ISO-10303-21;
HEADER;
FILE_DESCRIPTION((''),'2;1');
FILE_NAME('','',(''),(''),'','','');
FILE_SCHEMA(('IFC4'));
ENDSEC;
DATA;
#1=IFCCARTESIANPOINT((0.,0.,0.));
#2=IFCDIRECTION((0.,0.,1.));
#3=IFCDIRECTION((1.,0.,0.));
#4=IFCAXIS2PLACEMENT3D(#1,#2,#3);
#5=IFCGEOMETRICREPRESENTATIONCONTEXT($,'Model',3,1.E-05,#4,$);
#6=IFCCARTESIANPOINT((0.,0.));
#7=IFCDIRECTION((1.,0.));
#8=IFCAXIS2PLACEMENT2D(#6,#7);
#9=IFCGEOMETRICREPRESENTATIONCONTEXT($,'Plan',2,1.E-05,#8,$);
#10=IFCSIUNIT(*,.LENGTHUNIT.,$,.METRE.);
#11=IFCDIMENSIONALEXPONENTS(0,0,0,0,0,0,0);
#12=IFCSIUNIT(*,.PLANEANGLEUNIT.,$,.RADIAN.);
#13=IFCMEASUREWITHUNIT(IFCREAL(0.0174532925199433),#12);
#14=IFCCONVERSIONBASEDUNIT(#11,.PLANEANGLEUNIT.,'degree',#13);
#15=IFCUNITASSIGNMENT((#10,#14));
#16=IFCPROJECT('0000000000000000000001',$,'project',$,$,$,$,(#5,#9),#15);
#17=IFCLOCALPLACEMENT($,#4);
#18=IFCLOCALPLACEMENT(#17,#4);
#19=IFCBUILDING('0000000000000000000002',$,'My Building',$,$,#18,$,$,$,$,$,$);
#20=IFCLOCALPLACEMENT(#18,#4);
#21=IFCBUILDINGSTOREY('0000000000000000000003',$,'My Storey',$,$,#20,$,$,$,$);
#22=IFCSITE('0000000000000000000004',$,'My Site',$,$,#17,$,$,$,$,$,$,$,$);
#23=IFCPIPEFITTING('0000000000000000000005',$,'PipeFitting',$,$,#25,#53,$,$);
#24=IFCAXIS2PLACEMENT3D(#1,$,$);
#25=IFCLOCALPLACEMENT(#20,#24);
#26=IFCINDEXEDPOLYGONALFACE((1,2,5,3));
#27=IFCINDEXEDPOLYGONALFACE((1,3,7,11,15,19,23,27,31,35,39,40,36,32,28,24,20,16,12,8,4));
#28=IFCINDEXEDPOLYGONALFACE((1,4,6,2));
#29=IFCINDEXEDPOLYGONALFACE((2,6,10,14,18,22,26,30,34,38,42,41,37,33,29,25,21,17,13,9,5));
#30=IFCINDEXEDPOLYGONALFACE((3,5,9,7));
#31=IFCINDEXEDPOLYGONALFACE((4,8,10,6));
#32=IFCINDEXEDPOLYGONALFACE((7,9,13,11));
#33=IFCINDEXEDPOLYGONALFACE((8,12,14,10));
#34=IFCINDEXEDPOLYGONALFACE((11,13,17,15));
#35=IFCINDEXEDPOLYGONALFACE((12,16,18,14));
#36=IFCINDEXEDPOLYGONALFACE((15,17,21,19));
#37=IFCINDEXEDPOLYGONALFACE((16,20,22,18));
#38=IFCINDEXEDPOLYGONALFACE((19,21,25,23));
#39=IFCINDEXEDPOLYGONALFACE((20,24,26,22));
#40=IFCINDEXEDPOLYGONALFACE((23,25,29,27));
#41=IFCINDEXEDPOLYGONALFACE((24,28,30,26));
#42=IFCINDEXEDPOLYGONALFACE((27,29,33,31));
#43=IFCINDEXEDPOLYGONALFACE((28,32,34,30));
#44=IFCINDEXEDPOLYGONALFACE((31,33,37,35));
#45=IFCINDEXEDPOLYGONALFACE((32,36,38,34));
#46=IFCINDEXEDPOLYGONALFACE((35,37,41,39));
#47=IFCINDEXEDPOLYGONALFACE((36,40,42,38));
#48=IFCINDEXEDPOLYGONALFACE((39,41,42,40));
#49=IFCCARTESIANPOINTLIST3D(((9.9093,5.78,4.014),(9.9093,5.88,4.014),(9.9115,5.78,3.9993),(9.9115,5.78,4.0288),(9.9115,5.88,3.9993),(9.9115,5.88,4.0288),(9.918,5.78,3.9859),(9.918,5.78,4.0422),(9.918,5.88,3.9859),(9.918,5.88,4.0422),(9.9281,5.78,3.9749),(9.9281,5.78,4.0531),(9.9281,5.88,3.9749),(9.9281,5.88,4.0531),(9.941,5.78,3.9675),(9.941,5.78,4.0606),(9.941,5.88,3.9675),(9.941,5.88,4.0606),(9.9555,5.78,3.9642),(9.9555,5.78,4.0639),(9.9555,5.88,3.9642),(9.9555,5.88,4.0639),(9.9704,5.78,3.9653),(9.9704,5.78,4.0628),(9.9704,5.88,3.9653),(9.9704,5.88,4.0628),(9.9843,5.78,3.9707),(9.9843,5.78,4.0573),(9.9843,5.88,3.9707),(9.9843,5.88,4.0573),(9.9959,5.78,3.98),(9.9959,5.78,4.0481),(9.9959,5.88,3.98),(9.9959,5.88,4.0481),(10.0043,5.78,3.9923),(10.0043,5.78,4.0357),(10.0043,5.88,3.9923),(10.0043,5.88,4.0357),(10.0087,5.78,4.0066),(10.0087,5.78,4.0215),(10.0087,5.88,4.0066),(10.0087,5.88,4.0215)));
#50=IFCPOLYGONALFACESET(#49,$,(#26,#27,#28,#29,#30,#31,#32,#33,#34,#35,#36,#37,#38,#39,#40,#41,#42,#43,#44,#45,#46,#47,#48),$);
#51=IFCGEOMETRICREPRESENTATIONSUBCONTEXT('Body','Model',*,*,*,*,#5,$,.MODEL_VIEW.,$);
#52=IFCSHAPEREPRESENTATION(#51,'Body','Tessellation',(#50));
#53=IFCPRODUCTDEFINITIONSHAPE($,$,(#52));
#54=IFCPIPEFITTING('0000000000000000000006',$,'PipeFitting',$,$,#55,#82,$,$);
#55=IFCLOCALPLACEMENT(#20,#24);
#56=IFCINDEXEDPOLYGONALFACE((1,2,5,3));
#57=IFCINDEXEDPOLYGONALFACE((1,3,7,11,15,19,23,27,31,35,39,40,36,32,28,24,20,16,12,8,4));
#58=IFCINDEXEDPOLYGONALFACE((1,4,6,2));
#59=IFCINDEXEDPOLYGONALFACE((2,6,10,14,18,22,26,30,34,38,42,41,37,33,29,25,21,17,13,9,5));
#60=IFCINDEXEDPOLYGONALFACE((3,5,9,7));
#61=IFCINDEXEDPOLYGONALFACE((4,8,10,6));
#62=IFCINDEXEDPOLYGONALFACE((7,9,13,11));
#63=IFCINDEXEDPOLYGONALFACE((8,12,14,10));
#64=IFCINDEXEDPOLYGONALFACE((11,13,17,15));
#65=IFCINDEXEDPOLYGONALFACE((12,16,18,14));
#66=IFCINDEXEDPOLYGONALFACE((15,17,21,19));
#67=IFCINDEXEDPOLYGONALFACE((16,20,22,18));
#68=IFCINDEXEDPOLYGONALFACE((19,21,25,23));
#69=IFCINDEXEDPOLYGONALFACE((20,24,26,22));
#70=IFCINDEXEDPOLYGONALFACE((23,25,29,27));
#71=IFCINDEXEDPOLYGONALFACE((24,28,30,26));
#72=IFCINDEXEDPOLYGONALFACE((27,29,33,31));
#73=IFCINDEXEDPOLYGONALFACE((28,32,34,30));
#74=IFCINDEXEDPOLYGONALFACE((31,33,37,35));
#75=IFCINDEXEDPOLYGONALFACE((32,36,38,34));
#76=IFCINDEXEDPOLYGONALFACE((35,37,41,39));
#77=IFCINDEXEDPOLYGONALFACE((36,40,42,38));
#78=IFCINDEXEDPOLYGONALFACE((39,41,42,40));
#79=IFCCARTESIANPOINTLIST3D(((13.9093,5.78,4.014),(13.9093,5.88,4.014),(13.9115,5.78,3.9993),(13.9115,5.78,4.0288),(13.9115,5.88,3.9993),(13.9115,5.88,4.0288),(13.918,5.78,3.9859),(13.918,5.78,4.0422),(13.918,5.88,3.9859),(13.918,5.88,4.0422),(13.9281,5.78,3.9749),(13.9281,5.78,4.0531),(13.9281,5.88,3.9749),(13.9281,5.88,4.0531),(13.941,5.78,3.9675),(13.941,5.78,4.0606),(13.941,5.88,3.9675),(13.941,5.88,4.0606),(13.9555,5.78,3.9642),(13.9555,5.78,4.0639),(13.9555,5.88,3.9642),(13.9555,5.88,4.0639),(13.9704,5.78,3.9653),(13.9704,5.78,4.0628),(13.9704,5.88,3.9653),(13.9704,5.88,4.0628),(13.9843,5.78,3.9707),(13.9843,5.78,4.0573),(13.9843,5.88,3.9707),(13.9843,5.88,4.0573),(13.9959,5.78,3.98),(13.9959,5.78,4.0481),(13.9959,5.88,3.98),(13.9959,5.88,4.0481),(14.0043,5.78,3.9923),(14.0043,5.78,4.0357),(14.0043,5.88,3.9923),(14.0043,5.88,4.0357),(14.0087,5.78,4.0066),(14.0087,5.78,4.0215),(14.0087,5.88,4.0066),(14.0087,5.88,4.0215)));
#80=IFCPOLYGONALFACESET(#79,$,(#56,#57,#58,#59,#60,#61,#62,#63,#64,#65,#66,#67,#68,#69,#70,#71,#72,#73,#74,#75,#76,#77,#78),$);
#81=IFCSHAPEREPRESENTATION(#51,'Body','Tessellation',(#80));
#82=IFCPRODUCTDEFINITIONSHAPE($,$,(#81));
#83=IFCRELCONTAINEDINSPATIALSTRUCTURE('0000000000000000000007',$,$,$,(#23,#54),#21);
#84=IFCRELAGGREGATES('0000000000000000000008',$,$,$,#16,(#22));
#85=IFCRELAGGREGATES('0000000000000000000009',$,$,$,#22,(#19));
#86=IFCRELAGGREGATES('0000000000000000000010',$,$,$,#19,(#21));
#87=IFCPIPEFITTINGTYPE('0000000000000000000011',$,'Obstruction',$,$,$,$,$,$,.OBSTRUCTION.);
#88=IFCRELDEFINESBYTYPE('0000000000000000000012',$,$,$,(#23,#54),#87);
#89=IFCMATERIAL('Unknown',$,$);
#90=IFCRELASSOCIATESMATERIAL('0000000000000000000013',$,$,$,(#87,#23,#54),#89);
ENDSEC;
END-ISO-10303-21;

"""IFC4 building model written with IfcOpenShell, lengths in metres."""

from ifc_helpers import new_model, entity, si_unit, converted_unit, frame, origin_with_axes, origin_2d_with_axis, place, context, subcontext, project, spatial, circle, extrude, material, material_profile, profile_set, profile_usage, type_object, element, save


model = new_model("IFC4")

# Units and contexts
model_context = context("Model", 3, precision=1e-05, world=origin_with_axes())
plan_context = context("Plan", 2, precision=1e-05, world=origin_2d_with_axis())
body_context_1 = subcontext(model_context, "Body", "Model", "MODEL_VIEW")
ifc_project = project(units=[si_unit("LENGTHUNIT", "METRE"), converted_unit("PLANEANGLEUNIT", "degree", entity("IfcReal", 0.0174532925199433), si_unit("PLANEANGLEUNIT", "RADIAN"), dimensions=[0, 0, 0, 0, 0, 0, 0])], contexts=[model_context, plan_context])

# Site, building, storey
site_placement = place(None, origin_with_axes())
site = spatial("IfcSite", under=ifc_project, at=site_placement, Name="My Site")
building_placement = place(site_placement, origin_with_axes())
building = spatial("IfcBuilding", under=site, at=building_placement, Name="My Building")
storey_placement = place(building_placement, origin_with_axes())
storey = spatial("IfcBuildingStorey", under=building, at=storey_placement, Name="My Storey")

# Shared definitions
ifc_material = material(Name="Unknown")

# Pipe fittings
ifc_material_profile_1 = material_profile(ifc_material, circle(Radius=0.05))
ifc_profile_set_1 = profile_set([ifc_material_profile_1])
ifc_profile_usage_1 = profile_usage(ifc_profile_set_1, cardinal=5)
pipe_fitting_type_1 = type_object("IfcPipeFittingType", Name="Obstruction", PredefinedType="OBSTRUCTION", material=ifc_profile_set_1)
pipe_fitting_1_placement = place(storey_placement, frame((9.9593, 5.78, 4.014), z_axis=(0.0, 1.0, 0.0), x_axis=(-1.0, 0.0, 0.0)))
element("IfcPipeFitting", 1, at=pipe_fitting_1_placement, inside=storey, type_object=pipe_fitting_type_1, material=ifc_profile_usage_1, Name="PipeFitting", context=body_context_1, shape_type="SweptSolid", body=[
    extrude(circle(Radius=0.05), origin_with_axes(), (0.0, 0.0, 1.0), 0.1),
])
ifc_profile_usage_2 = profile_usage(ifc_profile_set_1, cardinal=5)
pipe_fitting_2_placement = place(storey_placement, frame((13.9593, 5.78, 4.014), z_axis=(0.0, 1.0, 0.0), x_axis=(-1.0, 0.0, 0.0)))
element("IfcPipeFitting", 2, at=pipe_fitting_2_placement, inside=storey, type_object=pipe_fitting_type_1, material=ifc_profile_usage_2, Name="PipeFitting", context=body_context_1, shape_type="SweptSolid", body=[
    extrude(circle(Radius=0.05), origin_with_axes(), (0.0, 0.0, 1.0), 0.1),
])

save(model, "model.ifc")
